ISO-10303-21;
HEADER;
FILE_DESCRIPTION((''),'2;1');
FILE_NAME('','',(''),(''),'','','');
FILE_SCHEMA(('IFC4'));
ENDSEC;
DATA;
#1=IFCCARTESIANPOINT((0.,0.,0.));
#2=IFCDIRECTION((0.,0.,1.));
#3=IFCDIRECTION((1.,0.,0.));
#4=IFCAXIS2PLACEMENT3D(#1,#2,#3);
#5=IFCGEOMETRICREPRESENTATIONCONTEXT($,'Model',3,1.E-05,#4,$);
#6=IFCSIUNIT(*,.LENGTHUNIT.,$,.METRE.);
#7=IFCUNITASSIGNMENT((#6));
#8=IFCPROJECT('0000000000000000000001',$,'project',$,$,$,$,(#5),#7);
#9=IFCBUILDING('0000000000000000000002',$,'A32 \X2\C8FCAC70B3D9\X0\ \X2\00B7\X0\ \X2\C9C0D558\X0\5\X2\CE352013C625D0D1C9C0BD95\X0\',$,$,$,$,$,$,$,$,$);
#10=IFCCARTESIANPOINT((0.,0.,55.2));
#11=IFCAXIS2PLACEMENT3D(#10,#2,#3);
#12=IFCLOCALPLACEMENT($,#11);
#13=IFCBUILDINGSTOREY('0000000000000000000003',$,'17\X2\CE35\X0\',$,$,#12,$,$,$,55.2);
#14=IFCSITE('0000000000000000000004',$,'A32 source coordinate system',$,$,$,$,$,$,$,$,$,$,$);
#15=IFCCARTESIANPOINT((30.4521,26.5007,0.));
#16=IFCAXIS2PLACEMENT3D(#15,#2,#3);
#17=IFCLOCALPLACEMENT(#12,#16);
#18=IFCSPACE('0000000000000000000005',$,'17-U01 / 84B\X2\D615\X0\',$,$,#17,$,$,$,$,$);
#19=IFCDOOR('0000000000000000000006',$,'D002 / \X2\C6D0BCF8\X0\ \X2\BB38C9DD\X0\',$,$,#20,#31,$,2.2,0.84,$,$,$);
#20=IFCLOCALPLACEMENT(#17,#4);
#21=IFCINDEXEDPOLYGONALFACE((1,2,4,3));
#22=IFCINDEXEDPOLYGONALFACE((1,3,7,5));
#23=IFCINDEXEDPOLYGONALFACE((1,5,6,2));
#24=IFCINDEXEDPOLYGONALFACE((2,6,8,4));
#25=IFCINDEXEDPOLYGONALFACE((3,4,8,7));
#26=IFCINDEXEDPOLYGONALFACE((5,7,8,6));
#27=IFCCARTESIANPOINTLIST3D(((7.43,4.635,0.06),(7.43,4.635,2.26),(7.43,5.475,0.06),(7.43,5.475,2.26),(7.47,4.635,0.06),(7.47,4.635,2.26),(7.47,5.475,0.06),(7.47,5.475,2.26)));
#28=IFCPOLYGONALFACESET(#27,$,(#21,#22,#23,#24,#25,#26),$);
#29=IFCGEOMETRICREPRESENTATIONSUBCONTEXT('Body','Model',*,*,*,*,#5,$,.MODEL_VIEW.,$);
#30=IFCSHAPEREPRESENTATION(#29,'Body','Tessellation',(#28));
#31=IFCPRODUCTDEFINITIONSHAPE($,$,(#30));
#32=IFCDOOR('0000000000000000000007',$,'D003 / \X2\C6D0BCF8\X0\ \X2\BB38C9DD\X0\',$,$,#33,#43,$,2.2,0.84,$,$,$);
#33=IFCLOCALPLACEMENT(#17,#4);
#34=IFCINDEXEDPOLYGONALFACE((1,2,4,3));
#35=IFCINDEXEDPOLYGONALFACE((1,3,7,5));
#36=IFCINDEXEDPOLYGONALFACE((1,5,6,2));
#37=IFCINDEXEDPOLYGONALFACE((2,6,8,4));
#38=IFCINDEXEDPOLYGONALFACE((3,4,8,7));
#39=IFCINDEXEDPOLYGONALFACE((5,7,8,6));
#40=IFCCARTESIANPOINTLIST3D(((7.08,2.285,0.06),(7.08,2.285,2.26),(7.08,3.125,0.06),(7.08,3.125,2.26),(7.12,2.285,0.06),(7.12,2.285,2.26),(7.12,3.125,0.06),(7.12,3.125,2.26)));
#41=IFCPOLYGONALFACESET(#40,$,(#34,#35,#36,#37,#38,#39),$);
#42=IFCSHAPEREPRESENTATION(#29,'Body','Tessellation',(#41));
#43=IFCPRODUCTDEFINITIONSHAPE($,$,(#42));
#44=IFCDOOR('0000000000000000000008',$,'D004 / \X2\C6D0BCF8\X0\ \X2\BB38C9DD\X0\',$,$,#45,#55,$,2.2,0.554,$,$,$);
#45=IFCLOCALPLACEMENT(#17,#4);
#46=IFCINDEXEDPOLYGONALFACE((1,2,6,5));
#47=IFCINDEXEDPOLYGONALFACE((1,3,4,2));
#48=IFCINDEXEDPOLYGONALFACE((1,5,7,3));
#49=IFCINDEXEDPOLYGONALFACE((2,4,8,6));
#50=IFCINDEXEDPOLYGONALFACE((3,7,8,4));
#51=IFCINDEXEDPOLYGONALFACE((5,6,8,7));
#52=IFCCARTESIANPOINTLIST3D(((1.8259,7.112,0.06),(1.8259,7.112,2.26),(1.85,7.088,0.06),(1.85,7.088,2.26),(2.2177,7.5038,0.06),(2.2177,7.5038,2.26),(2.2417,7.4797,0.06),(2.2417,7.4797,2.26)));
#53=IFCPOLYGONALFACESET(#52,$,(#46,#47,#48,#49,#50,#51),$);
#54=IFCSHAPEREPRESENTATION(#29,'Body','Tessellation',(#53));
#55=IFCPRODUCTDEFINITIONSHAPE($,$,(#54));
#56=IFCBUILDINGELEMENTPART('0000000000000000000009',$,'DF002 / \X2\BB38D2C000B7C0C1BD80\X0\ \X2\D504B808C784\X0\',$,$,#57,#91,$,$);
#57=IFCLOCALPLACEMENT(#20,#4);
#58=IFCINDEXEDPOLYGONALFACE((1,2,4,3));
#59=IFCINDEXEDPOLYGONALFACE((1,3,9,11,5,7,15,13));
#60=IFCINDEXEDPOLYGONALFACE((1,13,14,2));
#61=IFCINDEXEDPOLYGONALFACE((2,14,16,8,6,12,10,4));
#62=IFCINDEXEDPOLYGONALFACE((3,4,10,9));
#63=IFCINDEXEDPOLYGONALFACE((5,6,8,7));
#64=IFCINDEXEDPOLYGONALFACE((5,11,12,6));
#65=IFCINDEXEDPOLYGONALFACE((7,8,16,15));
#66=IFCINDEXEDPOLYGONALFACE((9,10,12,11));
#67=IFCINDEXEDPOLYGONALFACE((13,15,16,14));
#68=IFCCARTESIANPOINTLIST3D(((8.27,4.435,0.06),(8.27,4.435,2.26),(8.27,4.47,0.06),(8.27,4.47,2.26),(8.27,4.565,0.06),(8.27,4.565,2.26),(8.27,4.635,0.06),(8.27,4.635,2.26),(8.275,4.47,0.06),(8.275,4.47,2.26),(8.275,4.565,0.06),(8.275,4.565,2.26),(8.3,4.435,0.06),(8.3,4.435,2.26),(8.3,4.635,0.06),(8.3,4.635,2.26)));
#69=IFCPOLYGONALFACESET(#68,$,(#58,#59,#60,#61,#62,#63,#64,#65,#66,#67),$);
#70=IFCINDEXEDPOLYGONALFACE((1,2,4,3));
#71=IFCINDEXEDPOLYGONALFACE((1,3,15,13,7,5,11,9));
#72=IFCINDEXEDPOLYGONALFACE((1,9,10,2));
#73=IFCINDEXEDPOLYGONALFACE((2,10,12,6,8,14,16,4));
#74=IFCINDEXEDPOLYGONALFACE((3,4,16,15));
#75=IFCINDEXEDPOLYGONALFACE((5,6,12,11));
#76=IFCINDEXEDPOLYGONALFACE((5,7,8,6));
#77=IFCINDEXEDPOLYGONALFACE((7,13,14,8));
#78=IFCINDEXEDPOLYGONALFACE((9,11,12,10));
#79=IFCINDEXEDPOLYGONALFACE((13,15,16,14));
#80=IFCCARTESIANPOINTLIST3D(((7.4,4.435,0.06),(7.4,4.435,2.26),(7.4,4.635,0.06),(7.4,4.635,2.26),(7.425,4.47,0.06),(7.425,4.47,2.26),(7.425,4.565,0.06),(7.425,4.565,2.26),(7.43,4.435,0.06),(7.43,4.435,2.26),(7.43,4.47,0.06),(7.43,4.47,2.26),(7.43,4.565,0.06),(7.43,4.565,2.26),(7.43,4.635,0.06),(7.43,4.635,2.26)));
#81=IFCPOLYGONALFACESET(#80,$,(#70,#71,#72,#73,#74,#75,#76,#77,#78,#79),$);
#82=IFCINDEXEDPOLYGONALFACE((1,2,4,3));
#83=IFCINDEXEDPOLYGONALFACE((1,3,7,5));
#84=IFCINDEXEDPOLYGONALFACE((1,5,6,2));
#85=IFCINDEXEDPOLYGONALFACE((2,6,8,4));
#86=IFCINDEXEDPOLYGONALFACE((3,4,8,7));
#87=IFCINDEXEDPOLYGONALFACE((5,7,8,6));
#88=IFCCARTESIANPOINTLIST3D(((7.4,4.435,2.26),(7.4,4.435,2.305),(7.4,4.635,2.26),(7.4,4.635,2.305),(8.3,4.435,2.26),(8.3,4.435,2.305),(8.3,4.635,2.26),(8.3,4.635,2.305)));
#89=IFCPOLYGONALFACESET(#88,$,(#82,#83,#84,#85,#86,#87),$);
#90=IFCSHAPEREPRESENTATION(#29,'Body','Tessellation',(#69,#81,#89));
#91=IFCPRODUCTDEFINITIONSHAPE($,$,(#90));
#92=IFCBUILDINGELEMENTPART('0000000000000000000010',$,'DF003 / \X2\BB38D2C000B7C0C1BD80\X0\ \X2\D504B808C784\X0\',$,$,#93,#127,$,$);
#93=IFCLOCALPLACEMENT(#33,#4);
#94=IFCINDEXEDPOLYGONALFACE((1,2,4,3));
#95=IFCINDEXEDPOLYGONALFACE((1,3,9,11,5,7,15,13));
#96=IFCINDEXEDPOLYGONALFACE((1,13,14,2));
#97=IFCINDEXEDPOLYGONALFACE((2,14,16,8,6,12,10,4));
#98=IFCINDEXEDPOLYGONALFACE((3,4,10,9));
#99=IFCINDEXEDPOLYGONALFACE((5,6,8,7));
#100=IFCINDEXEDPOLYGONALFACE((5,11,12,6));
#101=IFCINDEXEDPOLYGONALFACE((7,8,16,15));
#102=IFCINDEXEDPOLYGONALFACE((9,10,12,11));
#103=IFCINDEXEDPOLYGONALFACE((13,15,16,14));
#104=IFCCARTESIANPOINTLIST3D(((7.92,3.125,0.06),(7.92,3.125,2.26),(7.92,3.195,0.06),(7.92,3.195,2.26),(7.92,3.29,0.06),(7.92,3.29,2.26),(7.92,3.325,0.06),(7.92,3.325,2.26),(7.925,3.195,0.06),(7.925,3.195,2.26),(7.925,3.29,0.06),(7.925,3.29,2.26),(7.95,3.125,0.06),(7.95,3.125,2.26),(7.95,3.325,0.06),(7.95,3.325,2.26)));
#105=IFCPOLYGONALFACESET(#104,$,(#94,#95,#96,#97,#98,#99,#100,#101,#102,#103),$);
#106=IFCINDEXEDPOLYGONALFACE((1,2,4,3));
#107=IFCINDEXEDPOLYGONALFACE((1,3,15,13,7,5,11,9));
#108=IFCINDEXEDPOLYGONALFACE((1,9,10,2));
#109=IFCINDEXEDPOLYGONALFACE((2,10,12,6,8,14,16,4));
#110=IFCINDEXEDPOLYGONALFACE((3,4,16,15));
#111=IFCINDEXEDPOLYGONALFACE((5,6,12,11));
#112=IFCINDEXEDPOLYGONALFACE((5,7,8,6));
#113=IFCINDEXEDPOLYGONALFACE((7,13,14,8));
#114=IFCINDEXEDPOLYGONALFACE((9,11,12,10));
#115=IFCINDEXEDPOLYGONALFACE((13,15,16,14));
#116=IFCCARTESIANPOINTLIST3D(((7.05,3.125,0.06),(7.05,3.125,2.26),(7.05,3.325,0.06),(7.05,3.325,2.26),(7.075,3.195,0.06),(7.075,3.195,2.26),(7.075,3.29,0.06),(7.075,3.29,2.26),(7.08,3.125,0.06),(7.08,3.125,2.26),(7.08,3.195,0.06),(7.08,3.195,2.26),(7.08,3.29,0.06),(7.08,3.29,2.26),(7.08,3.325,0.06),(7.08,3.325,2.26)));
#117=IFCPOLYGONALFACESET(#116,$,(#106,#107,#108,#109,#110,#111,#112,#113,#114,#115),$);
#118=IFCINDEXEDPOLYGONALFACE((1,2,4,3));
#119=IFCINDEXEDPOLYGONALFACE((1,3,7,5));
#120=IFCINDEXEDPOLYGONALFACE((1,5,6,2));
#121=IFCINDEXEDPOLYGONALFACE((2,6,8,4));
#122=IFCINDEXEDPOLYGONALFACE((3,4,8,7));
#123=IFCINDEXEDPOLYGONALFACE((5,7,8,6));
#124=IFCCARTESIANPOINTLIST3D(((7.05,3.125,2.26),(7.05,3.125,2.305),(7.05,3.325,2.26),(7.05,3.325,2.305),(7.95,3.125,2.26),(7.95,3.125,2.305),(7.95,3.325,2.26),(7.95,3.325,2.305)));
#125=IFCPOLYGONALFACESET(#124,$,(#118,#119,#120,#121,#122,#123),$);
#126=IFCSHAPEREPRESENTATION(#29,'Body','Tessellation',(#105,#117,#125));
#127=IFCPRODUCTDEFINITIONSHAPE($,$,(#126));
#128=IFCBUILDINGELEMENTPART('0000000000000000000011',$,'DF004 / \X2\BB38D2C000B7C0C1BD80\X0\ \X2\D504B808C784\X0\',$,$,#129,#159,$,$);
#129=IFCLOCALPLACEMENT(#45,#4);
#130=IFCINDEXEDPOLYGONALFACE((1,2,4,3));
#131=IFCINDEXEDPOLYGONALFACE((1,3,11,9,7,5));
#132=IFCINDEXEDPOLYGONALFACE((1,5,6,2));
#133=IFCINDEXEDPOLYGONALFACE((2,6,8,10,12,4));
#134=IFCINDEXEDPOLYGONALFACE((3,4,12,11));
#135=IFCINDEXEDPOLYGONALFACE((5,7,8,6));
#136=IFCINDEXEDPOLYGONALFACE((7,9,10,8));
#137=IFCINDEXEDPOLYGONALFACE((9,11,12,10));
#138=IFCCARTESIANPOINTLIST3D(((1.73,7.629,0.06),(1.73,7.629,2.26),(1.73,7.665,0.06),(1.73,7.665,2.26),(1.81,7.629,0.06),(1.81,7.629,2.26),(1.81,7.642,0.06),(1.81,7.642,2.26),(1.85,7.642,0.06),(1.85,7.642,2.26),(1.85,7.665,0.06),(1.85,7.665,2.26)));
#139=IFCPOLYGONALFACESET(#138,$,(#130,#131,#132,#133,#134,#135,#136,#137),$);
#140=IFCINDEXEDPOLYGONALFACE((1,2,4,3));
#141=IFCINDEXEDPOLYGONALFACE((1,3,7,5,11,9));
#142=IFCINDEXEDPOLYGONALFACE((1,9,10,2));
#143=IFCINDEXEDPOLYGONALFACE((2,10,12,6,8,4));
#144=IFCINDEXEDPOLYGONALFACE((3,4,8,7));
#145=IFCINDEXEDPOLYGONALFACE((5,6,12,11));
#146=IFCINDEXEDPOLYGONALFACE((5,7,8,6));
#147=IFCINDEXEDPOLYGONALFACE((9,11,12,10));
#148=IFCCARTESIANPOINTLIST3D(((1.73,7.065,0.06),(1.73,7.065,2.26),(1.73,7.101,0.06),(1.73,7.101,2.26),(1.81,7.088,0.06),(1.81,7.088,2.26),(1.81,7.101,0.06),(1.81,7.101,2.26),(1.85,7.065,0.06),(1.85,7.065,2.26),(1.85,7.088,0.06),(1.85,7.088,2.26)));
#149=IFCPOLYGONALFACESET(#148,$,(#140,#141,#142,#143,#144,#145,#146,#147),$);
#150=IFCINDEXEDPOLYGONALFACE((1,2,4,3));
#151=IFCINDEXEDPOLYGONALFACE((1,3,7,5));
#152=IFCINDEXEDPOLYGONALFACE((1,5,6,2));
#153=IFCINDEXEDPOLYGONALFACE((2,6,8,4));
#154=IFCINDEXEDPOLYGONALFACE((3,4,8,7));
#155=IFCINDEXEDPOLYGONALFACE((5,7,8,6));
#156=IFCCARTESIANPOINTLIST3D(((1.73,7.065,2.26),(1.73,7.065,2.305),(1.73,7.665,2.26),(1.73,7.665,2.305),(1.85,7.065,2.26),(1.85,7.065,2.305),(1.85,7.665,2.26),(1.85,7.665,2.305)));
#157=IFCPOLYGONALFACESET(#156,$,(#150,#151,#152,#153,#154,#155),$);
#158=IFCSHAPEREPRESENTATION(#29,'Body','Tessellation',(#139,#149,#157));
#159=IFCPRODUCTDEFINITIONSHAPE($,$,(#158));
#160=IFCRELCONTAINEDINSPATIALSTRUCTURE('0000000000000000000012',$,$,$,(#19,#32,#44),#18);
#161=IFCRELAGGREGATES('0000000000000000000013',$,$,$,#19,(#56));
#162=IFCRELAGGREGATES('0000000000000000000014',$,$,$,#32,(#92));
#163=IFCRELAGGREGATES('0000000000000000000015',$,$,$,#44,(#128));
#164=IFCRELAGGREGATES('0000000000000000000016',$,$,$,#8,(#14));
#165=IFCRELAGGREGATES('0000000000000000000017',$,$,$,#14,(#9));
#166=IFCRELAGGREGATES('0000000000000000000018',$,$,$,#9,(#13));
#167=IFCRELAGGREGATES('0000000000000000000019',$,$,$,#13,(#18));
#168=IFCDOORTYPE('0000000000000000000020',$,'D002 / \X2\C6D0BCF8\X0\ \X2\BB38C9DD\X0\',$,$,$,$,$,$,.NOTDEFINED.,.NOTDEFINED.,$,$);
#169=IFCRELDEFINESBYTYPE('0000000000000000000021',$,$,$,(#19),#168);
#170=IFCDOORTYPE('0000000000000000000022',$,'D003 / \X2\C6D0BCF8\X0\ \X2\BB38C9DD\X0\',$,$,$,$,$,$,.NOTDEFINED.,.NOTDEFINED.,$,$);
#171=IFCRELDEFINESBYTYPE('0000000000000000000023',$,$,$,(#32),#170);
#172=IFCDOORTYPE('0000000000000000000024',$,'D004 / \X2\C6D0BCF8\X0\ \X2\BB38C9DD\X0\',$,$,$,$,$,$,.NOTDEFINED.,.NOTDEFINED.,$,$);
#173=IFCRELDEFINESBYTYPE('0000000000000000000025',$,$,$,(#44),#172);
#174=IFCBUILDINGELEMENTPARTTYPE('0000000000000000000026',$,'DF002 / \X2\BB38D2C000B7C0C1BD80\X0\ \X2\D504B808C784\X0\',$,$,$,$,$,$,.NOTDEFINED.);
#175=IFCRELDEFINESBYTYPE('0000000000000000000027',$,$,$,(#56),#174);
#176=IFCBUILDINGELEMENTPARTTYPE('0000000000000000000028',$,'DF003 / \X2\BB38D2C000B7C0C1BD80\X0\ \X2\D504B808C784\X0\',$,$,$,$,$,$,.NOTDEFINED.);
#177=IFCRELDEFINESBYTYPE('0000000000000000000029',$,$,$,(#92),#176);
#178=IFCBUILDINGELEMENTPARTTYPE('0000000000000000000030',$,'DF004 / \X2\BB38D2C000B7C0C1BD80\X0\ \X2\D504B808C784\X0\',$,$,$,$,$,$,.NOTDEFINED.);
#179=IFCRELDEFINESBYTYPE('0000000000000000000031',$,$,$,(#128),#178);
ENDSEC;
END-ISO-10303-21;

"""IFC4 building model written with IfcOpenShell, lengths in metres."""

from ifc_helpers import new_model, si_unit, frame, origin, origin_with_axes, place, context, subcontext, project, spatial, polyline, outline, extrude, source, transform, mapped, type_object, type_shapes, element, aggregate, save


model = new_model("IFC4")

# Units and contexts
model_context = context("Model", 3, precision=1e-05, world=origin_with_axes())
body_context = subcontext(model_context, "Body", "Model", "MODEL_VIEW")
ifc_project = project(units=[si_unit("LENGTHUNIT", "METRE")], contexts=[model_context])

# Site, building, storey, space
storey_placement = place(None, frame((0.0, 0.0, 55.2), z_axis=(0.0, 0.0, 1.0), x_axis=(1.0, 0.0, 0.0)))
space_placement = place(storey_placement, frame((30.4521, 26.5007, 0.0), z_axis=(0.0, 0.0, 1.0), x_axis=(1.0, 0.0, 0.0)))
site = spatial("IfcSite", under=ifc_project, Name="A32 source coordinate system")
building = spatial("IfcBuilding", under=site, Name="A32 주거동 · 지하5층–옥탑지붕")
storey = spatial("IfcBuildingStorey", under=building, at=storey_placement, Name="17층", Elevation=55.2)
space = spatial("IfcSpace", under=storey, at=space_placement, Name="17-U01 / 84B형")

# Doors
door_type_1 = type_object("IfcDoorType", Name="D002 / 원본 문짝", OperationType="NOTDEFINED", PredefinedType="NOTDEFINED")
shared_shape_1 = source(origin(), body_context, "Body", "SweptSolid", [
    extrude(outline(polyline([(7.43, 4.635), (7.43, 5.475), (7.47, 5.475), (7.47, 4.635), (7.43, 4.635)])), frame((0.0, 0.0, 0.06)), (0.0, 0.0, 1.0), 2.2),
])
type_shapes(door_type_1, [shared_shape_1])
door_1_placement = place(space_placement, origin_with_axes())
door_1 = element("IfcDoor", 1, at=door_1_placement, inside=space, type_object=door_type_1, Name="D002 / 원본 문짝", OverallHeight=2.2, OverallWidth=0.84, context=body_context, shape_type="MappedRepresentation", body=[
    mapped(shared_shape_1, transform((0.0, 0.0, 0.0), scale=1.0)),
])
door_type_2 = type_object("IfcDoorType", Name="D003 / 원본 문짝", OperationType="NOTDEFINED", PredefinedType="NOTDEFINED")
shared_shape_2 = source(origin(), body_context, "Body", "SweptSolid", [
    extrude(outline(polyline([(7.12, 2.285), (7.08, 2.285), (7.08, 3.125), (7.12, 3.125), (7.12, 2.285)])), frame((0.0, 0.0, 0.06)), (0.0, 0.0, 1.0), 2.2),
])
type_shapes(door_type_2, [shared_shape_2])
door_2_placement = place(space_placement, origin_with_axes())
door_2 = element("IfcDoor", 2, at=door_2_placement, inside=space, type_object=door_type_2, Name="D003 / 원본 문짝", OverallHeight=2.2, OverallWidth=0.84, context=body_context, shape_type="MappedRepresentation", body=[
    mapped(shared_shape_2, transform((0.0, 0.0, 0.0), scale=1.0)),
])
door_type_3 = type_object("IfcDoorType", Name="D004 / 원본 문짝", OperationType="NOTDEFINED", PredefinedType="NOTDEFINED")
shared_shape_3 = source(origin(), body_context, "Body", "SweptSolid", [
    extrude(outline(polyline([(2.2177, 7.5038), (2.2417, 7.4797), (1.85, 7.088), (1.8259, 7.112), (2.2177, 7.5038)])), frame((0.0, 0.0, 0.06)), (0.0, 0.0, 1.0), 2.2),
])
type_shapes(door_type_3, [shared_shape_3])
door_3_placement = place(space_placement, origin_with_axes())
door_3 = element("IfcDoor", 3, at=door_3_placement, inside=space, type_object=door_type_3, Name="D004 / 원본 문짝", OverallHeight=2.2, OverallWidth=0.554, context=body_context, shape_type="MappedRepresentation", body=[
    mapped(shared_shape_3, transform((0.0, 0.0, 0.0), scale=1.0)),
])

# Building element parts
building_element_part_type_1 = type_object("IfcBuildingElementPartType", Name="DF002 / 문틀·상부 프레임", PredefinedType="NOTDEFINED")
shared_shape_4 = source(origin(), body_context, "Body", "SweptSolid", [
    extrude(outline(polyline([(8.3, 4.435), (8.27, 4.435), (8.27, 4.47), (8.275, 4.47), (8.275, 4.565), (8.27, 4.565), (8.27, 4.635), (8.3, 4.635), (8.3, 4.435)])), frame((0.0, 0.0, 0.06)), (0.0, 0.0, 1.0), 2.2),
    extrude(outline(polyline([(7.43, 4.635), (7.43, 4.565), (7.425, 4.565), (7.425, 4.47), (7.43, 4.47), (7.43, 4.435), (7.4, 4.435), (7.4, 4.635), (7.43, 4.635)])), frame((0.0, 0.0, 0.06)), (0.0, 0.0, 1.0), 2.2),
    extrude(outline(polyline([(7.4, 4.435), (7.4, 4.635), (8.3, 4.635), (8.3, 4.435), (7.4, 4.435)])), frame((0.0, 0.0, 2.26)), (0.0, 0.0, 1.0), 0.045),
])
type_shapes(building_element_part_type_1, [shared_shape_4])
building_element_part_1_placement = place(door_1_placement, origin_with_axes())
building_element_part_1 = element("IfcBuildingElementPart", 4, at=building_element_part_1_placement, type_object=building_element_part_type_1, Name="DF002 / 문틀·상부 프레임", context=body_context, shape_type="MappedRepresentation", body=[
    mapped(shared_shape_4, transform((0.0, 0.0, 0.0), scale=1.0)),
])
aggregate(door_1, [building_element_part_1])
building_element_part_type_2 = type_object("IfcBuildingElementPartType", Name="DF003 / 문틀·상부 프레임", PredefinedType="NOTDEFINED")
shared_shape_5 = source(origin(), body_context, "Body", "SweptSolid", [
    extrude(outline(polyline([(7.92, 3.125), (7.92, 3.195), (7.925, 3.195), (7.925, 3.29), (7.92, 3.29), (7.92, 3.325), (7.95, 3.325), (7.95, 3.125), (7.92, 3.125)])), frame((0.0, 0.0, 0.06)), (0.0, 0.0, 1.0), 2.2),
    extrude(outline(polyline([(7.05, 3.325), (7.08, 3.325), (7.08, 3.29), (7.075, 3.29), (7.075, 3.195), (7.08, 3.195), (7.08, 3.125), (7.05, 3.125), (7.05, 3.325)])), frame((0.0, 0.0, 0.06)), (0.0, 0.0, 1.0), 2.2),
    extrude(outline(polyline([(7.05, 3.125), (7.05, 3.325), (7.95, 3.325), (7.95, 3.125), (7.05, 3.125)])), frame((0.0, 0.0, 2.26)), (0.0, 0.0, 1.0), 0.045),
])
type_shapes(building_element_part_type_2, [shared_shape_5])
building_element_part_2_placement = place(door_2_placement, origin_with_axes())
building_element_part_2 = element("IfcBuildingElementPart", 5, at=building_element_part_2_placement, type_object=building_element_part_type_2, Name="DF003 / 문틀·상부 프레임", context=body_context, shape_type="MappedRepresentation", body=[
    mapped(shared_shape_5, transform((0.0, 0.0, 0.0), scale=1.0)),
])
aggregate(door_2, [building_element_part_2])
building_element_part_type_3 = type_object("IfcBuildingElementPartType", Name="DF004 / 문틀·상부 프레임", PredefinedType="NOTDEFINED")
shared_shape_6 = source(origin(), body_context, "Body", "SweptSolid", [
    extrude(outline(polyline([(1.85, 7.665), (1.85, 7.642), (1.81, 7.642), (1.81, 7.629), (1.73, 7.629), (1.73, 7.665), (1.85, 7.665)])), frame((0.0, 0.0, 0.06)), (0.0, 0.0, 1.0), 2.2),
    extrude(outline(polyline([(1.73, 7.101), (1.81, 7.101), (1.81, 7.088), (1.85, 7.088), (1.85, 7.065), (1.73, 7.065), (1.73, 7.101)])), frame((0.0, 0.0, 0.06)), (0.0, 0.0, 1.0), 2.2),
    extrude(outline(polyline([(1.73, 7.065), (1.73, 7.665), (1.85, 7.665), (1.85, 7.065), (1.73, 7.065)])), frame((0.0, 0.0, 2.26)), (0.0, 0.0, 1.0), 0.045),
])
type_shapes(building_element_part_type_3, [shared_shape_6])
building_element_part_3_placement = place(door_3_placement, origin_with_axes())
building_element_part_3 = element("IfcBuildingElementPart", 6, at=building_element_part_3_placement, type_object=building_element_part_type_3, Name="DF004 / 문틀·상부 프레임", context=body_context, shape_type="MappedRepresentation", body=[
    mapped(shared_shape_6, transform((0.0, 0.0, 0.0), scale=1.0)),
])
aggregate(door_3, [building_element_part_3])

save(model, "model.ifc")
